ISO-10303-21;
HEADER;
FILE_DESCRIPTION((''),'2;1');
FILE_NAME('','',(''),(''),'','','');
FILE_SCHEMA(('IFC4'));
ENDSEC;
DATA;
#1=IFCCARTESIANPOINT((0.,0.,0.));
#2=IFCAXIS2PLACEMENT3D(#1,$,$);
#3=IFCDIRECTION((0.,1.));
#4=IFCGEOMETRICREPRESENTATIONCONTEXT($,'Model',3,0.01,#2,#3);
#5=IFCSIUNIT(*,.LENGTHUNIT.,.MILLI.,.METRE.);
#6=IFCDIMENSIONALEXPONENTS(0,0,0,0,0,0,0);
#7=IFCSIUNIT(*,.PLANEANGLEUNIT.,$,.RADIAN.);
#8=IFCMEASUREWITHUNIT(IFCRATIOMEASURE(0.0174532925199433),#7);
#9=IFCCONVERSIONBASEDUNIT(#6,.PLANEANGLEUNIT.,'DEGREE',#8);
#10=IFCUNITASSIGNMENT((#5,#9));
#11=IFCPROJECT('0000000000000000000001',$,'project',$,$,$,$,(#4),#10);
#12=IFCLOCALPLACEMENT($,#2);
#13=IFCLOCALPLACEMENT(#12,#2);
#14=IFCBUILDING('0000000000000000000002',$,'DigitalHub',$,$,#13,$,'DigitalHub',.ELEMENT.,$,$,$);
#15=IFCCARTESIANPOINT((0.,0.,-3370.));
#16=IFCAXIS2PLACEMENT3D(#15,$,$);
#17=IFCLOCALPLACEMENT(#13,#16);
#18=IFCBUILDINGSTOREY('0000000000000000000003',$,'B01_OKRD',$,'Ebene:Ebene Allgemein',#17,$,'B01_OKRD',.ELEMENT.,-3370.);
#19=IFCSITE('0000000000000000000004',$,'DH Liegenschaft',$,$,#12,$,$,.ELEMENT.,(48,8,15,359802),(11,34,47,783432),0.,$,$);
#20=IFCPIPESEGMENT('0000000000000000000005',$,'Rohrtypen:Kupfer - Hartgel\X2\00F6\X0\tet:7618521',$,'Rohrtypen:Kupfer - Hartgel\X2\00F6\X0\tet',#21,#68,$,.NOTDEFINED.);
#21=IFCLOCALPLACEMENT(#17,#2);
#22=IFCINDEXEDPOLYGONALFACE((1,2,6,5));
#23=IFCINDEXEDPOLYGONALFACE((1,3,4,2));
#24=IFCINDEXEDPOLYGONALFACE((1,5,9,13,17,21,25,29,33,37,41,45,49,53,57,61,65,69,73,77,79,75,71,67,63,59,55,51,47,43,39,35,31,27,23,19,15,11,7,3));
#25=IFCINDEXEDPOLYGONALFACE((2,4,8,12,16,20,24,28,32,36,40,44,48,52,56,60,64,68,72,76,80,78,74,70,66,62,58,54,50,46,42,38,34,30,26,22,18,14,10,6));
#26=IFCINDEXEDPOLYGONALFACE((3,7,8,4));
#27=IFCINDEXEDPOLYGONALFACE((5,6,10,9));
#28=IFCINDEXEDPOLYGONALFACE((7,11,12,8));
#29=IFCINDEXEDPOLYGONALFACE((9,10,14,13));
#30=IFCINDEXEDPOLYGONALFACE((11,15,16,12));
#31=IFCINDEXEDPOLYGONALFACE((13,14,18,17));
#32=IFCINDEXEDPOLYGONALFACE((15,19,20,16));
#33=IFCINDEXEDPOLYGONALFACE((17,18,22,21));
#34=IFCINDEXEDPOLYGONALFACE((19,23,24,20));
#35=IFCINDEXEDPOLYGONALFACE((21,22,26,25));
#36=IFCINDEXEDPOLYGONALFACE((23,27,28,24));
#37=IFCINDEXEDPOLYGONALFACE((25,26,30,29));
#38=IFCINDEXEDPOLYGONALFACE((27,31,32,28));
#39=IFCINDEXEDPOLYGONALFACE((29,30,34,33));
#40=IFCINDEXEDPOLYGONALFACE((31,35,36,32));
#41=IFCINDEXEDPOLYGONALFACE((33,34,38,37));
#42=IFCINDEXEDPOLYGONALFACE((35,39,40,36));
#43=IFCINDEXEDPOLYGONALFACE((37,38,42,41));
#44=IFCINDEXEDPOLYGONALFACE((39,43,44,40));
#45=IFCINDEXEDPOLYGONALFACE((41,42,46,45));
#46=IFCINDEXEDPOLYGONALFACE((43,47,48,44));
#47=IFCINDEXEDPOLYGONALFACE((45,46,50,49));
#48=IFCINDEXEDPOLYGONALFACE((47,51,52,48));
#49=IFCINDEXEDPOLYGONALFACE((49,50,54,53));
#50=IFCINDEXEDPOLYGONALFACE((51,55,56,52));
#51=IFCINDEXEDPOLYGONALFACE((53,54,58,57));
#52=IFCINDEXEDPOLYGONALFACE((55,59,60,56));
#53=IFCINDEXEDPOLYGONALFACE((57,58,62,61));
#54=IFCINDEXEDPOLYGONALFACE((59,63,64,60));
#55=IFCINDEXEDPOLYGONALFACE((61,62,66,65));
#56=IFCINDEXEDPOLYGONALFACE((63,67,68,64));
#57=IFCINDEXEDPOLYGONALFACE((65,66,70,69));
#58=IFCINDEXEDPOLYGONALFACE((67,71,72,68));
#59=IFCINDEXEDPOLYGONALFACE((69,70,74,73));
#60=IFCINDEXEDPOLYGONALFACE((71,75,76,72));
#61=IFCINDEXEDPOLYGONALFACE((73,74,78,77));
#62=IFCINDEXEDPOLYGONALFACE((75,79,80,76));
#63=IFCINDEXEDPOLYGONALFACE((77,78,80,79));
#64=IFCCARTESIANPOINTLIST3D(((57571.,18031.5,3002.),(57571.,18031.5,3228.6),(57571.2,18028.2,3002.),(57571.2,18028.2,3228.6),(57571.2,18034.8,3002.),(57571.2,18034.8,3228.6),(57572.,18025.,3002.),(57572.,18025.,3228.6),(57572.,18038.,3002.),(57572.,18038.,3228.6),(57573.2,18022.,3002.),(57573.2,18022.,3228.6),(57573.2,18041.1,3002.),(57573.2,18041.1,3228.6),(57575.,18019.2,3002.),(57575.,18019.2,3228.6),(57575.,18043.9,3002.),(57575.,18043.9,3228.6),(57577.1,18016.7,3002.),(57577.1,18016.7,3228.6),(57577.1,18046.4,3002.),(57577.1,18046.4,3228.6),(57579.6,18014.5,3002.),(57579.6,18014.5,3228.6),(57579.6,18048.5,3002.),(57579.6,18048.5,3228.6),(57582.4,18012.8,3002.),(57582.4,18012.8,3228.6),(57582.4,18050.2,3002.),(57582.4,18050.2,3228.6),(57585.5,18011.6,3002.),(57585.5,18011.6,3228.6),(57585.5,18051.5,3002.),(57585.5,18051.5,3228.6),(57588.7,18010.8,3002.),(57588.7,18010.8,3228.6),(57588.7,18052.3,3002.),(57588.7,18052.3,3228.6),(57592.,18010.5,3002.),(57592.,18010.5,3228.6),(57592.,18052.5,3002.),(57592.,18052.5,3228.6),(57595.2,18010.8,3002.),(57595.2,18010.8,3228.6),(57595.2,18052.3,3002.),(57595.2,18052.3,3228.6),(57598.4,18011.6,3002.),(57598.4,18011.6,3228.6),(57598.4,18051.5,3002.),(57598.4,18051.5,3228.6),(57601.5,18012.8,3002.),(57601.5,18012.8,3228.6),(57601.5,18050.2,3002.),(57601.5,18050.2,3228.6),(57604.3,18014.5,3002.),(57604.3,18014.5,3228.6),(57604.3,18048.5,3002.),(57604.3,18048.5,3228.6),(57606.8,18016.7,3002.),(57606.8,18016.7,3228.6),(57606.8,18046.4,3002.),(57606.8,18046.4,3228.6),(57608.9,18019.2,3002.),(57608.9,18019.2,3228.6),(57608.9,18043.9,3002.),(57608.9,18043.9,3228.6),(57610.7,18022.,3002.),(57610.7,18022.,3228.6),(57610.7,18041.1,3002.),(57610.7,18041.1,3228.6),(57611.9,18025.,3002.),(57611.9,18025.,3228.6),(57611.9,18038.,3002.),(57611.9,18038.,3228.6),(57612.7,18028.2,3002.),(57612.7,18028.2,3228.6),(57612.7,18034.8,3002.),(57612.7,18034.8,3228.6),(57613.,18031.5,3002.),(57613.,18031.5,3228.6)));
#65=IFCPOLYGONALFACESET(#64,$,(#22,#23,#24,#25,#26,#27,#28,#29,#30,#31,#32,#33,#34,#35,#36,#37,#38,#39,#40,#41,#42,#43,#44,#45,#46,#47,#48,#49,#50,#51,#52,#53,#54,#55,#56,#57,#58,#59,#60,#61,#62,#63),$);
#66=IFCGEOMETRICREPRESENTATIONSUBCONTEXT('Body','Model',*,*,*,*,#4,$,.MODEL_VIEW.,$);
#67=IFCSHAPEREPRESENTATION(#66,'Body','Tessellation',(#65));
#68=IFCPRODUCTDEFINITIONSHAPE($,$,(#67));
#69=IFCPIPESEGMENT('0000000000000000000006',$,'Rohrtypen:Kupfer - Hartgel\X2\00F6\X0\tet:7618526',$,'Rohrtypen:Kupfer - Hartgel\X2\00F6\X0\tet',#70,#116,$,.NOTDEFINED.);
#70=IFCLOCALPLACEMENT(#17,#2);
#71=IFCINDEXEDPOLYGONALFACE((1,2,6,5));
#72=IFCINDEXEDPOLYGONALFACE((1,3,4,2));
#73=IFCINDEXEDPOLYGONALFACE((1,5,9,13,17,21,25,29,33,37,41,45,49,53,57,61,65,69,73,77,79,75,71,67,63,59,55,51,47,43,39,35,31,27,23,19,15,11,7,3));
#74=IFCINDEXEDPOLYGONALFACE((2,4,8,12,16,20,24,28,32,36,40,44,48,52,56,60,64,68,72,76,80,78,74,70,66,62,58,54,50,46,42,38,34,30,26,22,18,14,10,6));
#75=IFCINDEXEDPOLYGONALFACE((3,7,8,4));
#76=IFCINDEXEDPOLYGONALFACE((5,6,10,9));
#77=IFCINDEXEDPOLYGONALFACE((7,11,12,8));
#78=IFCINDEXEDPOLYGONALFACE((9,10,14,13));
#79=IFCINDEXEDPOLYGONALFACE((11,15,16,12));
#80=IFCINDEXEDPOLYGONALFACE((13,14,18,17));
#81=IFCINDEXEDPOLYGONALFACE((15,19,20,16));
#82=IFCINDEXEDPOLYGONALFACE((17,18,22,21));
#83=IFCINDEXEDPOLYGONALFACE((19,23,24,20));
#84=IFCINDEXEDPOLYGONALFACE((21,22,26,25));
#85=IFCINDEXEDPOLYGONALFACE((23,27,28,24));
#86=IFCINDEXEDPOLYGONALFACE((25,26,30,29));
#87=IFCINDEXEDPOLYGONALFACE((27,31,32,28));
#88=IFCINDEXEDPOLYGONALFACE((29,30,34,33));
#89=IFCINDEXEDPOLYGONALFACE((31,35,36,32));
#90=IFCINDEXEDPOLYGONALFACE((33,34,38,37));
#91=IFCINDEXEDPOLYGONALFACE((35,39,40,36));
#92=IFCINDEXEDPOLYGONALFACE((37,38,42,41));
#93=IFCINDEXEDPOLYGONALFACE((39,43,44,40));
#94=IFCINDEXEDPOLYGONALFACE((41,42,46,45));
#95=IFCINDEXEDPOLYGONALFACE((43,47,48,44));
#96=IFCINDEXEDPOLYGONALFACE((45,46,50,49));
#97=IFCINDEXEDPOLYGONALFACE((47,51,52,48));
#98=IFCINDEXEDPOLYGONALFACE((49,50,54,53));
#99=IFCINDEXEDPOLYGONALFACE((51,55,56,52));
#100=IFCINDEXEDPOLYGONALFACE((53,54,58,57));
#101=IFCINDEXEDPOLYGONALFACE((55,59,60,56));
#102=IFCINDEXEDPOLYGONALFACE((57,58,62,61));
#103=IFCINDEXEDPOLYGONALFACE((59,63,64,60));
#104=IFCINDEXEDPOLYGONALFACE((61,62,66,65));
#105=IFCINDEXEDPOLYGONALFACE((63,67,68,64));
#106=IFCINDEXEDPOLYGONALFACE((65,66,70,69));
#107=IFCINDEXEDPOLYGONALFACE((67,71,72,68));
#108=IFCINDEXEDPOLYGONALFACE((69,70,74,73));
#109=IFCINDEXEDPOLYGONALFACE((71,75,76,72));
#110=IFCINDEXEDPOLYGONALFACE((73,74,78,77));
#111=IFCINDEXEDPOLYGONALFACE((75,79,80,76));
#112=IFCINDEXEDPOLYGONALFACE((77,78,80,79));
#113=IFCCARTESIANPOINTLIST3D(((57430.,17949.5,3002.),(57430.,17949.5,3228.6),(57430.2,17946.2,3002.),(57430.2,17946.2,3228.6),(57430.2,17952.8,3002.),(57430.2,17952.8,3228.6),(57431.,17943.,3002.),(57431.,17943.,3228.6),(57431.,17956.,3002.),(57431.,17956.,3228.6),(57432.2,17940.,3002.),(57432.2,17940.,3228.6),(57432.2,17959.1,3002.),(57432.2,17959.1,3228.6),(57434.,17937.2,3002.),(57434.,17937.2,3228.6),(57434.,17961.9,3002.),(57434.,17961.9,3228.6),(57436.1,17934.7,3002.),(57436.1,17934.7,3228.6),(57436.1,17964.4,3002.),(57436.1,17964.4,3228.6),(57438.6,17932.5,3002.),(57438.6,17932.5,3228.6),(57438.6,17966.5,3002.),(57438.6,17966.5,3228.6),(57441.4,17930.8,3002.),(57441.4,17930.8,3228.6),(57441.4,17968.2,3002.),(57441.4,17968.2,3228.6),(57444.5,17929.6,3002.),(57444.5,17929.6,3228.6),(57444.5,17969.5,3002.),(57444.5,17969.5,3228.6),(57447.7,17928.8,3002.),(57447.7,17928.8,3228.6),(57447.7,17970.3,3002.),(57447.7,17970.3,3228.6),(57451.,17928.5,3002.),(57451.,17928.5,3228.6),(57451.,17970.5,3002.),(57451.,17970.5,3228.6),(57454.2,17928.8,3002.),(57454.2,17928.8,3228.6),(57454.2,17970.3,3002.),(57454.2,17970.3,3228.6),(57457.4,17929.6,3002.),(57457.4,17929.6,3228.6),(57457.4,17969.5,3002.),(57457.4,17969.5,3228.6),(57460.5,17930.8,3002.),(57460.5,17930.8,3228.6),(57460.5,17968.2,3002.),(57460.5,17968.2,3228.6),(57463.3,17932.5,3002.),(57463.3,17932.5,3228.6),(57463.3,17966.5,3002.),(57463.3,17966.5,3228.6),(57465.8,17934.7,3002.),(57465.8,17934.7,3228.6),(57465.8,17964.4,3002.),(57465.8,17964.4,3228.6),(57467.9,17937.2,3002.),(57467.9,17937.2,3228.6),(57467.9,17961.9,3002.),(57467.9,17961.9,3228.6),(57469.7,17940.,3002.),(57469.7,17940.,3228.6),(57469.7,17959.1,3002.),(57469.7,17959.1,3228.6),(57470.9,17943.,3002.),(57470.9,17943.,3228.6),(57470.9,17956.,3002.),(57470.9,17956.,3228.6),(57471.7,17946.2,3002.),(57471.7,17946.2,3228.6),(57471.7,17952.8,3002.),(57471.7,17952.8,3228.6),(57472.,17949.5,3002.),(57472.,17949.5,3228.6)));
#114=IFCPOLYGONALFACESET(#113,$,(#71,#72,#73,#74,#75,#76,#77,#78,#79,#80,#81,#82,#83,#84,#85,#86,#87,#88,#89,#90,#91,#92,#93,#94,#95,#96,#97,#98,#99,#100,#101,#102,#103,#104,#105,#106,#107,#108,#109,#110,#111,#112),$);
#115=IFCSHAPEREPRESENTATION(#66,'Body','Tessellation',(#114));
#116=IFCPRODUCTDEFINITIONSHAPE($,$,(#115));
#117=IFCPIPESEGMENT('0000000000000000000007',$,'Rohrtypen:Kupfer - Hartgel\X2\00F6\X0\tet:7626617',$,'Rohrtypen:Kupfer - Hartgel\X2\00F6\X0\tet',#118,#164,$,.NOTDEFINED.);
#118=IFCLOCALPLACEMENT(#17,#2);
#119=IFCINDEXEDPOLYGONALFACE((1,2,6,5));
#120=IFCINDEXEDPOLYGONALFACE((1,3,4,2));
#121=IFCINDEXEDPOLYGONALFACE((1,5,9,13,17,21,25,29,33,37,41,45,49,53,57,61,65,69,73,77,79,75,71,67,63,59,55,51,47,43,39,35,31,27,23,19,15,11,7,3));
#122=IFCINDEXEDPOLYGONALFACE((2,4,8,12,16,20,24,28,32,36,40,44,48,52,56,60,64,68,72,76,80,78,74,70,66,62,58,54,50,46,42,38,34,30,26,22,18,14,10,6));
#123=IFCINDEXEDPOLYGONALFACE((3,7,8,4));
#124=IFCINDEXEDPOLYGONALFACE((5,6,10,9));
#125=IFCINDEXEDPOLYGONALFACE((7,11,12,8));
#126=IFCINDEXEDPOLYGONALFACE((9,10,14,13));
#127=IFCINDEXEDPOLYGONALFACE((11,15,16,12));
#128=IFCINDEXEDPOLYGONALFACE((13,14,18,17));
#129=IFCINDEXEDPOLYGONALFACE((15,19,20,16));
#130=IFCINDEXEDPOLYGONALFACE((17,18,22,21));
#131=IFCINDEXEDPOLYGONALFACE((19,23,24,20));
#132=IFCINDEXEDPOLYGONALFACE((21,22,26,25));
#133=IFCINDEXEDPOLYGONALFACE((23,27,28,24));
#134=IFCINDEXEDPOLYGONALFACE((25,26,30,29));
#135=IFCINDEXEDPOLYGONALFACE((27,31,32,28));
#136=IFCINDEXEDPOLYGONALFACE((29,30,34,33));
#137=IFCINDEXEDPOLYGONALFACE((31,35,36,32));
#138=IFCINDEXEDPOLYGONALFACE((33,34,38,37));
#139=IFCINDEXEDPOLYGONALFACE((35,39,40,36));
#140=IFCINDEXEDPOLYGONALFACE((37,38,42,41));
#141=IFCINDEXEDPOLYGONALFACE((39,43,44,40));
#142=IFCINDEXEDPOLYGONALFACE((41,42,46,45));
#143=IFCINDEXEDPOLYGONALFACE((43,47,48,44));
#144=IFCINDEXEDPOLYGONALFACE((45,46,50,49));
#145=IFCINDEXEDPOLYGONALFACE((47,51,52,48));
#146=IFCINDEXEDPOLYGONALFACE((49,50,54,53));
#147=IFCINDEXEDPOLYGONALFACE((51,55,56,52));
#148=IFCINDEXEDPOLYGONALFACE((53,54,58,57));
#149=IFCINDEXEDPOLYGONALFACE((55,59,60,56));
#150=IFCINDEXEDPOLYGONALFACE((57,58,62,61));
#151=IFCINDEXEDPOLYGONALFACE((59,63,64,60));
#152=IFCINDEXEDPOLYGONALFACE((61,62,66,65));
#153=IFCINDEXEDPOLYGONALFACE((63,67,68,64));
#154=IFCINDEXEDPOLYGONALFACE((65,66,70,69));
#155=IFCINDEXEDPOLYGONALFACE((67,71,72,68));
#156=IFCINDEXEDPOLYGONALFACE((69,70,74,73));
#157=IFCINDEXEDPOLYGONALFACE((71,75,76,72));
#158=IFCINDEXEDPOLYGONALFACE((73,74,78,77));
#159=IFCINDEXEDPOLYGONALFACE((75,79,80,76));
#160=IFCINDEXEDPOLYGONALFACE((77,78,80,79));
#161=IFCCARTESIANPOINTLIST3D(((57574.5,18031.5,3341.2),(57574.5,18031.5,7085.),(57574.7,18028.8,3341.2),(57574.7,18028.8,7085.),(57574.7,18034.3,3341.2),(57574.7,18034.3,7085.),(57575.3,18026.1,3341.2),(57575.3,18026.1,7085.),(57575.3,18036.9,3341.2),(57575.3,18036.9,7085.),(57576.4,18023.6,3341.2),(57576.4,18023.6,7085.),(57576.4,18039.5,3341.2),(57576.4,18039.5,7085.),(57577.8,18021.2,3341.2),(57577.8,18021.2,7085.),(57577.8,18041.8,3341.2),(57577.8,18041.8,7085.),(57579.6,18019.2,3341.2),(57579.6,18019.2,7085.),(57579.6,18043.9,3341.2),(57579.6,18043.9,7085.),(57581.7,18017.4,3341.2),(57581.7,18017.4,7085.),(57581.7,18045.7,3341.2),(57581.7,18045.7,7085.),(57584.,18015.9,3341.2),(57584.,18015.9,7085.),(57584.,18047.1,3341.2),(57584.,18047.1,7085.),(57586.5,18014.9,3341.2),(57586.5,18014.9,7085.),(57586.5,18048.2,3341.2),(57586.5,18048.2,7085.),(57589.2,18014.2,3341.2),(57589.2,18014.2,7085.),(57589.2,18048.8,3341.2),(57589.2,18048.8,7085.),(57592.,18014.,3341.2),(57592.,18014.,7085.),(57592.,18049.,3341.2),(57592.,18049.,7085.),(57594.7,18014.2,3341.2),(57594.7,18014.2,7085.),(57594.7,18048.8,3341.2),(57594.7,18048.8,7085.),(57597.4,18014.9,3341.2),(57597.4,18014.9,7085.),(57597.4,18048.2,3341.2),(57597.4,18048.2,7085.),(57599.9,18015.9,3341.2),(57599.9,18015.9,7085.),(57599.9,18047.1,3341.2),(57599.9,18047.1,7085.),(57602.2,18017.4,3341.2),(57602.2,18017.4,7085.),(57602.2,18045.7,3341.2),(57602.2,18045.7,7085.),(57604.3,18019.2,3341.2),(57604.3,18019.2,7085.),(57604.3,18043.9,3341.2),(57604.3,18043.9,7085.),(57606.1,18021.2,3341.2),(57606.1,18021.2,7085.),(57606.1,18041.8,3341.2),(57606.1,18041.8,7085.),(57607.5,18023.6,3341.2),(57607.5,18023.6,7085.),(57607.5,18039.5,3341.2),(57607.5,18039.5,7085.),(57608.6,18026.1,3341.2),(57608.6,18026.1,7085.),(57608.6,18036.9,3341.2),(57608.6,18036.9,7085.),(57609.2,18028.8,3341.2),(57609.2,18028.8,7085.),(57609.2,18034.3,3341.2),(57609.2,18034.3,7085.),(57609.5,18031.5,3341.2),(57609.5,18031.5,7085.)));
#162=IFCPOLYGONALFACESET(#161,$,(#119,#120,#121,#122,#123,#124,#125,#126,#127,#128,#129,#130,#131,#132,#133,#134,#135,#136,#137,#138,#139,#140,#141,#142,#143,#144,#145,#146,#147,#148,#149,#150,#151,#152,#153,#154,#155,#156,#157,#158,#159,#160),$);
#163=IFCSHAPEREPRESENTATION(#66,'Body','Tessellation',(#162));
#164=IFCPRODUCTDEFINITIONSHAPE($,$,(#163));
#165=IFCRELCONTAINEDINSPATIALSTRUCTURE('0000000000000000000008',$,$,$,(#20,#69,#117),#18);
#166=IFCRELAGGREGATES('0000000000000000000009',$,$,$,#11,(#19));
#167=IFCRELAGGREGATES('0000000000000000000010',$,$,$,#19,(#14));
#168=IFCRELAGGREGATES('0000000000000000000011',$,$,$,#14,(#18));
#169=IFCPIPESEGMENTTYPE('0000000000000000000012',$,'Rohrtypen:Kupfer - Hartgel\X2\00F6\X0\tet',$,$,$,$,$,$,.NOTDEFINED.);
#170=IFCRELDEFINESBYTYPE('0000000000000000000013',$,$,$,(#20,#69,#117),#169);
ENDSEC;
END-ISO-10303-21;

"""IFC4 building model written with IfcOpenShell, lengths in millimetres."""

from ifc_helpers import new_model, entity, si_unit, converted_unit, direction, frame, origin, place, context, subcontext, project, spatial, indexed_curve, outline, extrude, type_object, element, save


model = new_model("IFC4")

# Units and contexts
model_context = context("Model", 3, precision=0.01, world=origin(), true_north=direction((0.0, 1.0)))
body_context = subcontext(model_context, "Body", "Model", "MODEL_VIEW")
ifc_project = project(units=[si_unit("LENGTHUNIT", "METRE", prefix="MILLI"), converted_unit("PLANEANGLEUNIT", "DEGREE", entity("IfcRatioMeasure", 0.0174532925199433), si_unit("PLANEANGLEUNIT", "RADIAN"), dimensions=[0, 0, 0, 0, 0, 0, 0])], contexts=[model_context])

# Site, building, storey
site_placement = place(None, origin())
site = spatial("IfcSite", under=ifc_project, at=site_placement, Name="DH Liegenschaft", CompositionType="ELEMENT", RefLatitude=(48, 8, 15, 359802), RefLongitude=(11, 34, 47, 783432), RefElevation=0.0)
building_placement = place(site_placement, origin())
building = spatial("IfcBuilding", under=site, at=building_placement, Name="DigitalHub", LongName="DigitalHub", CompositionType="ELEMENT")
storey_placement = place(building_placement, frame((0.0, 0.0, -3370.0)))
storey = spatial("IfcBuildingStorey", under=building, at=storey_placement, Name="B01_OKRD", ObjectType="Ebene:Ebene Allgemein", LongName="B01_OKRD", CompositionType="ELEMENT", Elevation=-3370.0)

# Pipe segments
pipe_segment_type = type_object("IfcPipeSegmentType", Name="Rohrtypen:Kupfer - Hartgelötet", PredefinedType="NOTDEFINED")
pipe_segment_1_placement = place(storey_placement, frame((57569.4, 18008.9, 3002.0)))
element("IfcPipeSegment", 1, at=pipe_segment_1_placement, inside=storey, type_object=pipe_segment_type, Name="Rohrtypen:Kupfer - Hartgelötet:7618521", ObjectType="Rohrtypen:Kupfer - Hartgelötet", PredefinedType="NOTDEFINED", context=body_context, shape_type="SweptSolid", body=[
    extrude(outline(indexed_curve([(21.0, 0.0), (20.7, 3.3), (20.0, 6.5), (18.7, 9.5), (17.0, 12.3), (14.8, 14.8), (12.3, 17.0), (9.5, 18.7), (6.5, 20.0), (3.3, 20.7), (0.0, 21.0), (-3.3, 20.7), (-6.5, 20.0), (-9.5, 18.7), (-12.3, 17.0), (-14.8, 14.8), (-17.0, 12.3), (-18.7, 9.5), (-20.0, 6.5), (-20.7, 3.3), (-21.0, 0.0), (-20.7, -3.3), (-20.0, -6.5), (-18.7, -9.5), (-17.0, -12.3), (-14.8, -14.8), (-12.3, -17.0), (-9.5, -18.7), (-6.5, -20.0), (-3.3, -20.7), (0.0, -21.0), (3.3, -20.7), (6.5, -20.0), (9.5, -18.7), (12.3, -17.0), (14.8, -14.8), (17.0, -12.3), (18.7, -9.5), (20.0, -6.5), (20.7, -3.3), (21.0, 0.0)], self_intersect=False)), frame((22.6, 22.6, 0.0), z_axis=(0.0, 0.0, 1.0), x_axis=(-1.0, 0.0, 0.0)), (0.0, 0.0, 1.0), 226.6),
])
pipe_segment_2_placement = place(storey_placement, frame((57428.4, 17926.9, 3002.0)))
element("IfcPipeSegment", 2, at=pipe_segment_2_placement, inside=storey, type_object=pipe_segment_type, Name="Rohrtypen:Kupfer - Hartgelötet:7618526", ObjectType="Rohrtypen:Kupfer - Hartgelötet", PredefinedType="NOTDEFINED", context=body_context, shape_type="SweptSolid", body=[
    extrude(outline(indexed_curve([(21.0, 0.0), (20.7, 3.3), (20.0, 6.5), (18.7, 9.5), (17.0, 12.3), (14.8, 14.8), (12.3, 17.0), (9.5, 18.7), (6.5, 20.0), (3.3, 20.7), (0.0, 21.0), (-3.3, 20.7), (-6.5, 20.0), (-9.5, 18.7), (-12.3, 17.0), (-14.8, 14.8), (-17.0, 12.3), (-18.7, 9.5), (-20.0, 6.5), (-20.7, 3.3), (-21.0, 0.0), (-20.7, -3.3), (-20.0, -6.5), (-18.7, -9.5), (-17.0, -12.3), (-14.8, -14.8), (-12.3, -17.0), (-9.5, -18.7), (-6.5, -20.0), (-3.3, -20.7), (0.0, -21.0), (3.3, -20.7), (6.5, -20.0), (9.5, -18.7), (12.3, -17.0), (14.8, -14.8), (17.0, -12.3), (18.7, -9.5), (20.0, -6.5), (20.7, -3.3), (21.0, 0.0)], self_intersect=False)), frame((22.6, 22.6, 0.0)), (0.0, 0.0, 1.0), 226.6),
])
pipe_segment_3_placement = place(storey_placement, frame((57572.9, 18012.4, 3341.2)))
element("IfcPipeSegment", 3, at=pipe_segment_3_placement, inside=storey, type_object=pipe_segment_type, Name="Rohrtypen:Kupfer - Hartgelötet:7626617", ObjectType="Rohrtypen:Kupfer - Hartgelötet", PredefinedType="NOTDEFINED", context=body_context, shape_type="SweptSolid", body=[
    extrude(outline(indexed_curve([(17.5, 0.0), (17.3, 2.7), (16.6, 5.4), (15.6, 7.9), (14.2, 10.3), (12.4, 12.4), (10.3, 14.2), (7.9, 15.6), (5.4, 16.6), (2.7, 17.3), (0.0, 17.5), (-2.7, 17.3), (-5.4, 16.6), (-7.9, 15.6), (-10.3, 14.2), (-12.4, 12.4), (-14.2, 10.3), (-15.6, 7.9), (-16.6, 5.4), (-17.3, 2.7), (-17.5, 0.0), (-17.3, -2.7), (-16.6, -5.4), (-15.6, -7.9), (-14.2, -10.3), (-12.4, -12.4), (-10.3, -14.2), (-7.9, -15.6), (-5.4, -16.6), (-2.7, -17.3), (0.0, -17.5), (2.7, -17.3), (5.4, -16.6), (7.9, -15.6), (10.3, -14.2), (12.4, -12.4), (14.2, -10.3), (15.6, -7.9), (16.6, -5.4), (17.3, -2.7), (17.5, 0.0)], self_intersect=False)), frame((19.1, 19.1, 0.0)), (0.0, 0.0, 1.0), 3743.8),
])

save(model, "model.ifc")
